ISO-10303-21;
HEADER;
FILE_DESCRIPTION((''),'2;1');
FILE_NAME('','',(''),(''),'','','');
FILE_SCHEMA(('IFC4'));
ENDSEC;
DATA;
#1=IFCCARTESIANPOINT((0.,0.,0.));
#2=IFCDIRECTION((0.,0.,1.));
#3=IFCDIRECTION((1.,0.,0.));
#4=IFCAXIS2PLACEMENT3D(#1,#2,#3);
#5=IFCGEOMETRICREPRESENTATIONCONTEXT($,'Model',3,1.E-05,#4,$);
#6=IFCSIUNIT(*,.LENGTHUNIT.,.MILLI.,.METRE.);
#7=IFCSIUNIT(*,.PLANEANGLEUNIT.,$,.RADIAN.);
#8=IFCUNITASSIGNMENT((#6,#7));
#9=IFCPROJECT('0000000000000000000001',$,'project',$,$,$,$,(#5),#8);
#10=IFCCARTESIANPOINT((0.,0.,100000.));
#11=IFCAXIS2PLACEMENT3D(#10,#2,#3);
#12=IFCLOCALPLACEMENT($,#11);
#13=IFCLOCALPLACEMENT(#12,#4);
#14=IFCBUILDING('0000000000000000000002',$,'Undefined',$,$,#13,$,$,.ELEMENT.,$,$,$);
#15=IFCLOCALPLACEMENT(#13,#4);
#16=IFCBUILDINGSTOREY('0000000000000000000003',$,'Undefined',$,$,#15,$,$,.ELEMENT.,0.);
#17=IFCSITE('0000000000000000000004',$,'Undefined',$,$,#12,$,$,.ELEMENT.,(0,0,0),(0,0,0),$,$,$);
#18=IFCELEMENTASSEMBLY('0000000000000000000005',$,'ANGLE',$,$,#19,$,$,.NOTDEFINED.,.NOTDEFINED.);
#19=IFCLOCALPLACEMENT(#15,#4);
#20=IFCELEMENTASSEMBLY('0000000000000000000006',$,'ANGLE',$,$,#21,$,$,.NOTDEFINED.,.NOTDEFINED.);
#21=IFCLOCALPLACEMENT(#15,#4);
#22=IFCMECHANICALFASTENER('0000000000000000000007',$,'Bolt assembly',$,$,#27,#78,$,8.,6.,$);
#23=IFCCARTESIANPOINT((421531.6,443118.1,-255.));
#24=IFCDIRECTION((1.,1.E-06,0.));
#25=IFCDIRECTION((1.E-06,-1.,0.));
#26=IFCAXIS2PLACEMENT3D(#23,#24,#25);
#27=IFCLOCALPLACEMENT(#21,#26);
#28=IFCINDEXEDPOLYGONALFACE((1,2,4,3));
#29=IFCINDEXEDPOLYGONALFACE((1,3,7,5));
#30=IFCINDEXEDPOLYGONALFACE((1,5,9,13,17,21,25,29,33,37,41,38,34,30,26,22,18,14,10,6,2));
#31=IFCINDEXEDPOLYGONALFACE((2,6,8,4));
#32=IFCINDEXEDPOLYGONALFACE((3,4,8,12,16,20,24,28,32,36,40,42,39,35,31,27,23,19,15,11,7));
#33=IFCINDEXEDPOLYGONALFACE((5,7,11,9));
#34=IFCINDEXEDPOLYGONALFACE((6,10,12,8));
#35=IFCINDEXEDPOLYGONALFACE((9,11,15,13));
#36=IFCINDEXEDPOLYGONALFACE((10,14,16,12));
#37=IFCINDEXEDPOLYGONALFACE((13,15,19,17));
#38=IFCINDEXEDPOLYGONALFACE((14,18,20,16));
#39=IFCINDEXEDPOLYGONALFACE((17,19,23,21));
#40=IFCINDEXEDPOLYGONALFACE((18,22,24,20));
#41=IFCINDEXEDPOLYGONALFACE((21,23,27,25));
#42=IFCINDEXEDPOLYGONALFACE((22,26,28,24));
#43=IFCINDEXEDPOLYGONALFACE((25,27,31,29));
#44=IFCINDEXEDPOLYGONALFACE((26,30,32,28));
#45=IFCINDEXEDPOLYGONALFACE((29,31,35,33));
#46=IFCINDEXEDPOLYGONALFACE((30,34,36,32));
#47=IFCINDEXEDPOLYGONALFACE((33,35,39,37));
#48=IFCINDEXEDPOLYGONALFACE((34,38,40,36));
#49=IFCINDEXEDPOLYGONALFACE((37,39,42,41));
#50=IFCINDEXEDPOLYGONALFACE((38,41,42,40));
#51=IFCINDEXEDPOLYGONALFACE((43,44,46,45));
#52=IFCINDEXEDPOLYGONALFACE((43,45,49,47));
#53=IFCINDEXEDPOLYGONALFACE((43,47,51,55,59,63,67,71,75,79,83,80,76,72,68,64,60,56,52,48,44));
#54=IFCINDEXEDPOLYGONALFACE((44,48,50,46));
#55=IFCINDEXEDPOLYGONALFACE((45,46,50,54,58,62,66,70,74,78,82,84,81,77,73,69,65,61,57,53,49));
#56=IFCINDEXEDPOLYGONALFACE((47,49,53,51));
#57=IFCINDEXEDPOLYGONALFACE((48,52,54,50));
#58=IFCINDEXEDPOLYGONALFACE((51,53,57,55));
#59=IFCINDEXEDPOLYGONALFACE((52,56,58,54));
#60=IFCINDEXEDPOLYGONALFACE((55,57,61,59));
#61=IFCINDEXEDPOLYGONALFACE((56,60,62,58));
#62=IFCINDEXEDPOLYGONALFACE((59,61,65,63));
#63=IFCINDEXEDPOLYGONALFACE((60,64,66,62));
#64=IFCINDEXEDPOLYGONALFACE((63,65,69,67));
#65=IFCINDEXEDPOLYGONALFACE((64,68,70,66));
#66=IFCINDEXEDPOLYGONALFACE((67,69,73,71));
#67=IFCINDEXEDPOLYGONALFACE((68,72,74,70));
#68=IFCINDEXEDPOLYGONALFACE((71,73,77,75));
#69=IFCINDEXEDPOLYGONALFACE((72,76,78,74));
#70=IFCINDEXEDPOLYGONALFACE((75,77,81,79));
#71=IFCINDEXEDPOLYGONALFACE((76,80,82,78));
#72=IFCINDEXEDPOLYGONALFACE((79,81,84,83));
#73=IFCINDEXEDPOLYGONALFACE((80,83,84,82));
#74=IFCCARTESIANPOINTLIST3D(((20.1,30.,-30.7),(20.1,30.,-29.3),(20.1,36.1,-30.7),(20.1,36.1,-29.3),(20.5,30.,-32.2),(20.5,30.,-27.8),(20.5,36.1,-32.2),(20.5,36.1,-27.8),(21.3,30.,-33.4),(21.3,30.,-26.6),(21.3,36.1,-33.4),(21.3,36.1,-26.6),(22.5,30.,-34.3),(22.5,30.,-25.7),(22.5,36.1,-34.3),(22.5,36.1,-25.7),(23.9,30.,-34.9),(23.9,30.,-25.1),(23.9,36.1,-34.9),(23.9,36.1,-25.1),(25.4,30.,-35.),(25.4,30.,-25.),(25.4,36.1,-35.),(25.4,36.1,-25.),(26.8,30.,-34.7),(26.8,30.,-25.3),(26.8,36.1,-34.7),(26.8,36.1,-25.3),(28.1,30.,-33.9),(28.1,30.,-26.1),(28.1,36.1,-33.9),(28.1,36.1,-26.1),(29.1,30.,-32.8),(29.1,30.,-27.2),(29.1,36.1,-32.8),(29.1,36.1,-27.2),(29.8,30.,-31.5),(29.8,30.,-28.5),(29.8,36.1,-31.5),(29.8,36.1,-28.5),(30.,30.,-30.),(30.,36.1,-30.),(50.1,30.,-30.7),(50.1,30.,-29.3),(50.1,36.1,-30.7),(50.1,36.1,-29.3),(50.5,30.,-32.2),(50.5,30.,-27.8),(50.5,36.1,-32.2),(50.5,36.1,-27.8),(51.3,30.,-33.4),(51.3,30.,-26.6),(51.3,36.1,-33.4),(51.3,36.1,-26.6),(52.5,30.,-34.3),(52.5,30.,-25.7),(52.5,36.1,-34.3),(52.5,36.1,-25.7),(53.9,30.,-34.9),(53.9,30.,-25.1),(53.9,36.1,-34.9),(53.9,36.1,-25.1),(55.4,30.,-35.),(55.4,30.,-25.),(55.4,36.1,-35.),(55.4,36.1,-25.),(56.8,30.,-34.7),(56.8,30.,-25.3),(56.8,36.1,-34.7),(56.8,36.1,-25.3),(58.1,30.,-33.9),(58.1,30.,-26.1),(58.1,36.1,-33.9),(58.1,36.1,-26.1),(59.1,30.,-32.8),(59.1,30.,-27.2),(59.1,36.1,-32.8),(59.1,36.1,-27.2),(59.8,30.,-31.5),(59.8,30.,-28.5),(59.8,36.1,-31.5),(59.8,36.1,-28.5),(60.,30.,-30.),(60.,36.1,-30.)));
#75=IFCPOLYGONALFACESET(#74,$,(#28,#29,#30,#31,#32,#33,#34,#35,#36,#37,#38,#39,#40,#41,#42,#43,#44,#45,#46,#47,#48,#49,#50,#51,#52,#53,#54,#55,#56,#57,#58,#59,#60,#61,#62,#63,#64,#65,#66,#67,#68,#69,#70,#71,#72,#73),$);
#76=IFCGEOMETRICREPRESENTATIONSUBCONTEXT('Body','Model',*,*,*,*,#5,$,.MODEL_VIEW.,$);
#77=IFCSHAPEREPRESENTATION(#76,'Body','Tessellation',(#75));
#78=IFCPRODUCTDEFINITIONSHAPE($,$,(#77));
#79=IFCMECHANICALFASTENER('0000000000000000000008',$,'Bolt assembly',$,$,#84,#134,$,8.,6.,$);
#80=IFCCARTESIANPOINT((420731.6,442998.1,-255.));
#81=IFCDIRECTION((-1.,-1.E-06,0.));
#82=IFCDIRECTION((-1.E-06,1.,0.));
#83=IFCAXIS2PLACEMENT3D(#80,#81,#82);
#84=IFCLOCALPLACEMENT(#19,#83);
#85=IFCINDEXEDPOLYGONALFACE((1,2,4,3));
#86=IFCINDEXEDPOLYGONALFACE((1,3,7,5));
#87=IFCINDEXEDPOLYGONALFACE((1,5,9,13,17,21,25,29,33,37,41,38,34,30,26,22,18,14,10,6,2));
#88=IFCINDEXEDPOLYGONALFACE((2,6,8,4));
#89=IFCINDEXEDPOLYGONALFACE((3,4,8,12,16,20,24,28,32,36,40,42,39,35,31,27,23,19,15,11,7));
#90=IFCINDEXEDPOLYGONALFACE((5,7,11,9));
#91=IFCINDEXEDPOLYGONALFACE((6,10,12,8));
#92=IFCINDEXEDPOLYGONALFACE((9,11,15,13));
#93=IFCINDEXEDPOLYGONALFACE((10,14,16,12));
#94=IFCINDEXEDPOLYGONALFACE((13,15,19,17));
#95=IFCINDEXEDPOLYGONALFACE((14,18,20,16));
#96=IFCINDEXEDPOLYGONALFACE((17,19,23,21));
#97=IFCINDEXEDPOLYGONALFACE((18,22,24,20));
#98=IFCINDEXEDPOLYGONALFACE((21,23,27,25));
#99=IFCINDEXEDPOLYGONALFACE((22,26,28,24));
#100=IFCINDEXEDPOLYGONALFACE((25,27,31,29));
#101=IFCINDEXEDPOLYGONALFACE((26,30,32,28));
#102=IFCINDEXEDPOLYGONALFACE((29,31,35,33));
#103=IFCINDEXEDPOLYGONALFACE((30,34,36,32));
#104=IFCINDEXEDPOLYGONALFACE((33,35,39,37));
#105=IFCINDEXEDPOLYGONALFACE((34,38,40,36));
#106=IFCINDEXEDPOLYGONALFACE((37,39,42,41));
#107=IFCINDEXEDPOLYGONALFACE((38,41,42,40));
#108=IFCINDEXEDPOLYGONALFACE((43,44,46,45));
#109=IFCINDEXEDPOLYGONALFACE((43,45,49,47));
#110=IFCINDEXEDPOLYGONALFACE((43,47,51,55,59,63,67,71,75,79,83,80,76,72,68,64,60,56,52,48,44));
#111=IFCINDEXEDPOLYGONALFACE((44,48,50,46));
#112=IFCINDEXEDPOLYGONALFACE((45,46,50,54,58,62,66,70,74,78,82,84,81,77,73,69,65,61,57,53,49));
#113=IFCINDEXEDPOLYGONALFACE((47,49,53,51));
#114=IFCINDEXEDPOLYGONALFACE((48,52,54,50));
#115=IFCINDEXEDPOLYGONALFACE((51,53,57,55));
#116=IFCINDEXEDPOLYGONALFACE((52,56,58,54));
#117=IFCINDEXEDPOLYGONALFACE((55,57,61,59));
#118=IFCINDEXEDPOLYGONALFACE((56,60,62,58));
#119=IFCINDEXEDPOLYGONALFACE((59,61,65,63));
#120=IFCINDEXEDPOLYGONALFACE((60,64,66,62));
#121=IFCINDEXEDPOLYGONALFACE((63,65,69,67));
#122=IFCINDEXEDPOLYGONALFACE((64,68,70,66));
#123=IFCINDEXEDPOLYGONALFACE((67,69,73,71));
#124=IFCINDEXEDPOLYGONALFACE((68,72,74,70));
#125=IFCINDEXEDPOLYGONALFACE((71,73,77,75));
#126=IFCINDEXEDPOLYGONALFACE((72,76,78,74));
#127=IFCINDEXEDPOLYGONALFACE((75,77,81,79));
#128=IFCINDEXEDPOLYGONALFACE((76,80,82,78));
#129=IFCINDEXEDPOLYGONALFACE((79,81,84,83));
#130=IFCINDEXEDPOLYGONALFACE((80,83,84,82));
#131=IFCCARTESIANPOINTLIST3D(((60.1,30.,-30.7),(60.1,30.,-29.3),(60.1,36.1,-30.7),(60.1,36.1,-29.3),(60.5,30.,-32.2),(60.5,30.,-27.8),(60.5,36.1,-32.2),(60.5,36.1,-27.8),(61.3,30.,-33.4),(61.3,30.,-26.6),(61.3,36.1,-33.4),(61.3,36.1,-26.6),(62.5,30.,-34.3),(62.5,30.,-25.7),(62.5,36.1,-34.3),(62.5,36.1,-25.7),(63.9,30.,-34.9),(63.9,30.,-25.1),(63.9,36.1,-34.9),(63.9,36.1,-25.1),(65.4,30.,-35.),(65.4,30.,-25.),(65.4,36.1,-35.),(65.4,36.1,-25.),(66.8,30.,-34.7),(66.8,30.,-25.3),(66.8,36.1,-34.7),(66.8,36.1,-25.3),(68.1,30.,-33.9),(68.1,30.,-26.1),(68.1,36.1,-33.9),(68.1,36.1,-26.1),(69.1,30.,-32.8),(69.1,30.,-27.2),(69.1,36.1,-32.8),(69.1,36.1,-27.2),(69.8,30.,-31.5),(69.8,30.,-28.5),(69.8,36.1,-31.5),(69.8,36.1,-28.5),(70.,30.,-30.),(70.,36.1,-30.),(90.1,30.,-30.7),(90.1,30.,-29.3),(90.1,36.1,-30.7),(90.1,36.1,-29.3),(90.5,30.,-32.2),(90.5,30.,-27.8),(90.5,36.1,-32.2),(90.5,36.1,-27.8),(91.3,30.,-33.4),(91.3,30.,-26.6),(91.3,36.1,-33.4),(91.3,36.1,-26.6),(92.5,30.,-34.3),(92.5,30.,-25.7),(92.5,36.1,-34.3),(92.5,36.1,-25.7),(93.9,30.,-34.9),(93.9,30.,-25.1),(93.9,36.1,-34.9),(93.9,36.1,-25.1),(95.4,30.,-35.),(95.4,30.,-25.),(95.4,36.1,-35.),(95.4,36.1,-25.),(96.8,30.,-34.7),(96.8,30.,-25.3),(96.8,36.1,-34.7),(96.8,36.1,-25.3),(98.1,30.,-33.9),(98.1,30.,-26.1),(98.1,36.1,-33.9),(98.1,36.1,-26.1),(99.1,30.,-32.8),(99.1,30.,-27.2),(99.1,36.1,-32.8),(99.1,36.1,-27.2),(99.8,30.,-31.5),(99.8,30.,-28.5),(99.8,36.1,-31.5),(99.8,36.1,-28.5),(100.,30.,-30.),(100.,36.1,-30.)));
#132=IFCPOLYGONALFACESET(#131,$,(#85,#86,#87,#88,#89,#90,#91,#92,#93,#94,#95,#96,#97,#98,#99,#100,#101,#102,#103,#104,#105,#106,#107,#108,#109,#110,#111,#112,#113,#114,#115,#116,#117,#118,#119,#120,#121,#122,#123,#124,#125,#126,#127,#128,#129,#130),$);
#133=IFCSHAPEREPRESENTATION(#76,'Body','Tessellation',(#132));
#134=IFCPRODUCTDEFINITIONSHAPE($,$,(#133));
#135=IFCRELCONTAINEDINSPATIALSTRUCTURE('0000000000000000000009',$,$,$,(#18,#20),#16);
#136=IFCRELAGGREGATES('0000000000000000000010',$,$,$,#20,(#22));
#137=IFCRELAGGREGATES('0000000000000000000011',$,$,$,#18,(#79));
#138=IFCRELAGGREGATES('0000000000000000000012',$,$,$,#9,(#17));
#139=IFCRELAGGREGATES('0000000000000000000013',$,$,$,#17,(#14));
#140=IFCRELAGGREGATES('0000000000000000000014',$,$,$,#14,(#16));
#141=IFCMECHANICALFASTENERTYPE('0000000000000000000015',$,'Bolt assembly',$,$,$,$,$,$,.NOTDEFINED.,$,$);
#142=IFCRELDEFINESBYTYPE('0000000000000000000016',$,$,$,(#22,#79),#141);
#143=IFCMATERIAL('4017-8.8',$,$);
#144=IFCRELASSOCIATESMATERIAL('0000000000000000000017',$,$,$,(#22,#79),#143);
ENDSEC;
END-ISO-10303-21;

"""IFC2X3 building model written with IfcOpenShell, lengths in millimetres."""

from ifc_helpers import new_model, si_unit, frame, origin_with_axes, origin_2d_with_axis, place, context, subcontext, project, spatial, circle, extrude, source, transform, mapped, material, type_object, element, aggregate, save


model = new_model("IFC2X3")

# Units and contexts
model_context = context("Model", 3, precision=1e-05, world=origin_with_axes())
body_context = subcontext(model_context, "Body", "Model", "MODEL_VIEW")
ifc_project = project(units=[si_unit("LENGTHUNIT", "METRE", prefix="MILLI"), si_unit("PLANEANGLEUNIT", "RADIAN")], contexts=[model_context])

# Site, building, storey
site_placement = place(None, frame((0.0, 0.0, 100000.0), z_axis=(0.0, 0.0, 1.0), x_axis=(1.0, 0.0, 0.0)))
site = spatial("IfcSite", under=ifc_project, at=site_placement, Name="Undefined", CompositionType="ELEMENT", RefLatitude=(0, 0, 0), RefLongitude=(0, 0, 0))
building_placement = place(site_placement, origin_with_axes())
building = spatial("IfcBuilding", under=site, at=building_placement, Name="Undefined", CompositionType="ELEMENT")
storey_placement = place(building_placement, origin_with_axes())
storey = spatial("IfcBuildingStorey", under=building, at=storey_placement, Name="Undefined", CompositionType="ELEMENT", Elevation=0.0)

# Element assembly
assembly_1_placement = place(storey_placement, origin_with_axes())
assembly_1 = element("IfcElementAssembly", 1, at=assembly_1_placement, inside=storey, Name="ANGLE", AssemblyPlace="NOTDEFINED", PredefinedType="NOTDEFINED")

# Shared definitions
ifc_material_1 = material(Name="4017-8.8")
mechanical_fastener_type = type_object("IfcMechanicalFastenerType", Name="Bolt assembly")

# Element assembly
assembly_2_placement = place(storey_placement, origin_with_axes())
assembly_2 = element("IfcElementAssembly", 2, at=assembly_2_placement, inside=storey, Name="ANGLE", AssemblyPlace="NOTDEFINED", PredefinedType="NOTDEFINED")

# Mechanical fasteners
shared_shape_1 = source(origin_with_axes(), body_context, "Body", "SweptSolid", [
    extrude(circle(Radius=5.0, at=origin_2d_with_axis()), frame((0.0, 30.0, 0.0), z_axis=(0.0, 1.0, 0.0), x_axis=(1.0, 0.0, 0.0)), (0.0, 0.0, 1.0), 6.1),
])
mechanical_fastener_1_placement = place(assembly_2_placement, frame((421531.6, 443118.1, -255.0), z_axis=(1.0, 0.000001, 0.0), x_axis=(0.000001, -1.0, 0.0)))
mechanical_fastener_1 = element("IfcMechanicalFastener", 3, at=mechanical_fastener_1_placement, type_object=mechanical_fastener_type, material=ifc_material_1, Name="Bolt assembly", NominalDiameter=8.0, NominalLength=6.0, context=body_context, shape_type="MappedRepresentation", body=[
    mapped(shared_shape_1, transform((25.0, 0.0, -30.0))),
    mapped(shared_shape_1, transform((55.0, 0.0, -30.0))),
])
aggregate(assembly_2, [mechanical_fastener_1])
mechanical_fastener_2_placement = place(assembly_1_placement, frame((420731.6, 442998.1, -255.0), z_axis=(-1.0, -0.000001, 0.0), x_axis=(-0.000001, 1.0, 0.0)))
mechanical_fastener_2 = element("IfcMechanicalFastener", 4, at=mechanical_fastener_2_placement, type_object=mechanical_fastener_type, material=ifc_material_1, Name="Bolt assembly", NominalDiameter=8.0, NominalLength=6.0, context=body_context, shape_type="MappedRepresentation", body=[
    mapped(shared_shape_1, transform((95.0, 0.0, -30.0))),
    mapped(shared_shape_1, transform((65.0, 0.0, -30.0))),
])
aggregate(assembly_1, [mechanical_fastener_2])

save(model, "model.ifc")
